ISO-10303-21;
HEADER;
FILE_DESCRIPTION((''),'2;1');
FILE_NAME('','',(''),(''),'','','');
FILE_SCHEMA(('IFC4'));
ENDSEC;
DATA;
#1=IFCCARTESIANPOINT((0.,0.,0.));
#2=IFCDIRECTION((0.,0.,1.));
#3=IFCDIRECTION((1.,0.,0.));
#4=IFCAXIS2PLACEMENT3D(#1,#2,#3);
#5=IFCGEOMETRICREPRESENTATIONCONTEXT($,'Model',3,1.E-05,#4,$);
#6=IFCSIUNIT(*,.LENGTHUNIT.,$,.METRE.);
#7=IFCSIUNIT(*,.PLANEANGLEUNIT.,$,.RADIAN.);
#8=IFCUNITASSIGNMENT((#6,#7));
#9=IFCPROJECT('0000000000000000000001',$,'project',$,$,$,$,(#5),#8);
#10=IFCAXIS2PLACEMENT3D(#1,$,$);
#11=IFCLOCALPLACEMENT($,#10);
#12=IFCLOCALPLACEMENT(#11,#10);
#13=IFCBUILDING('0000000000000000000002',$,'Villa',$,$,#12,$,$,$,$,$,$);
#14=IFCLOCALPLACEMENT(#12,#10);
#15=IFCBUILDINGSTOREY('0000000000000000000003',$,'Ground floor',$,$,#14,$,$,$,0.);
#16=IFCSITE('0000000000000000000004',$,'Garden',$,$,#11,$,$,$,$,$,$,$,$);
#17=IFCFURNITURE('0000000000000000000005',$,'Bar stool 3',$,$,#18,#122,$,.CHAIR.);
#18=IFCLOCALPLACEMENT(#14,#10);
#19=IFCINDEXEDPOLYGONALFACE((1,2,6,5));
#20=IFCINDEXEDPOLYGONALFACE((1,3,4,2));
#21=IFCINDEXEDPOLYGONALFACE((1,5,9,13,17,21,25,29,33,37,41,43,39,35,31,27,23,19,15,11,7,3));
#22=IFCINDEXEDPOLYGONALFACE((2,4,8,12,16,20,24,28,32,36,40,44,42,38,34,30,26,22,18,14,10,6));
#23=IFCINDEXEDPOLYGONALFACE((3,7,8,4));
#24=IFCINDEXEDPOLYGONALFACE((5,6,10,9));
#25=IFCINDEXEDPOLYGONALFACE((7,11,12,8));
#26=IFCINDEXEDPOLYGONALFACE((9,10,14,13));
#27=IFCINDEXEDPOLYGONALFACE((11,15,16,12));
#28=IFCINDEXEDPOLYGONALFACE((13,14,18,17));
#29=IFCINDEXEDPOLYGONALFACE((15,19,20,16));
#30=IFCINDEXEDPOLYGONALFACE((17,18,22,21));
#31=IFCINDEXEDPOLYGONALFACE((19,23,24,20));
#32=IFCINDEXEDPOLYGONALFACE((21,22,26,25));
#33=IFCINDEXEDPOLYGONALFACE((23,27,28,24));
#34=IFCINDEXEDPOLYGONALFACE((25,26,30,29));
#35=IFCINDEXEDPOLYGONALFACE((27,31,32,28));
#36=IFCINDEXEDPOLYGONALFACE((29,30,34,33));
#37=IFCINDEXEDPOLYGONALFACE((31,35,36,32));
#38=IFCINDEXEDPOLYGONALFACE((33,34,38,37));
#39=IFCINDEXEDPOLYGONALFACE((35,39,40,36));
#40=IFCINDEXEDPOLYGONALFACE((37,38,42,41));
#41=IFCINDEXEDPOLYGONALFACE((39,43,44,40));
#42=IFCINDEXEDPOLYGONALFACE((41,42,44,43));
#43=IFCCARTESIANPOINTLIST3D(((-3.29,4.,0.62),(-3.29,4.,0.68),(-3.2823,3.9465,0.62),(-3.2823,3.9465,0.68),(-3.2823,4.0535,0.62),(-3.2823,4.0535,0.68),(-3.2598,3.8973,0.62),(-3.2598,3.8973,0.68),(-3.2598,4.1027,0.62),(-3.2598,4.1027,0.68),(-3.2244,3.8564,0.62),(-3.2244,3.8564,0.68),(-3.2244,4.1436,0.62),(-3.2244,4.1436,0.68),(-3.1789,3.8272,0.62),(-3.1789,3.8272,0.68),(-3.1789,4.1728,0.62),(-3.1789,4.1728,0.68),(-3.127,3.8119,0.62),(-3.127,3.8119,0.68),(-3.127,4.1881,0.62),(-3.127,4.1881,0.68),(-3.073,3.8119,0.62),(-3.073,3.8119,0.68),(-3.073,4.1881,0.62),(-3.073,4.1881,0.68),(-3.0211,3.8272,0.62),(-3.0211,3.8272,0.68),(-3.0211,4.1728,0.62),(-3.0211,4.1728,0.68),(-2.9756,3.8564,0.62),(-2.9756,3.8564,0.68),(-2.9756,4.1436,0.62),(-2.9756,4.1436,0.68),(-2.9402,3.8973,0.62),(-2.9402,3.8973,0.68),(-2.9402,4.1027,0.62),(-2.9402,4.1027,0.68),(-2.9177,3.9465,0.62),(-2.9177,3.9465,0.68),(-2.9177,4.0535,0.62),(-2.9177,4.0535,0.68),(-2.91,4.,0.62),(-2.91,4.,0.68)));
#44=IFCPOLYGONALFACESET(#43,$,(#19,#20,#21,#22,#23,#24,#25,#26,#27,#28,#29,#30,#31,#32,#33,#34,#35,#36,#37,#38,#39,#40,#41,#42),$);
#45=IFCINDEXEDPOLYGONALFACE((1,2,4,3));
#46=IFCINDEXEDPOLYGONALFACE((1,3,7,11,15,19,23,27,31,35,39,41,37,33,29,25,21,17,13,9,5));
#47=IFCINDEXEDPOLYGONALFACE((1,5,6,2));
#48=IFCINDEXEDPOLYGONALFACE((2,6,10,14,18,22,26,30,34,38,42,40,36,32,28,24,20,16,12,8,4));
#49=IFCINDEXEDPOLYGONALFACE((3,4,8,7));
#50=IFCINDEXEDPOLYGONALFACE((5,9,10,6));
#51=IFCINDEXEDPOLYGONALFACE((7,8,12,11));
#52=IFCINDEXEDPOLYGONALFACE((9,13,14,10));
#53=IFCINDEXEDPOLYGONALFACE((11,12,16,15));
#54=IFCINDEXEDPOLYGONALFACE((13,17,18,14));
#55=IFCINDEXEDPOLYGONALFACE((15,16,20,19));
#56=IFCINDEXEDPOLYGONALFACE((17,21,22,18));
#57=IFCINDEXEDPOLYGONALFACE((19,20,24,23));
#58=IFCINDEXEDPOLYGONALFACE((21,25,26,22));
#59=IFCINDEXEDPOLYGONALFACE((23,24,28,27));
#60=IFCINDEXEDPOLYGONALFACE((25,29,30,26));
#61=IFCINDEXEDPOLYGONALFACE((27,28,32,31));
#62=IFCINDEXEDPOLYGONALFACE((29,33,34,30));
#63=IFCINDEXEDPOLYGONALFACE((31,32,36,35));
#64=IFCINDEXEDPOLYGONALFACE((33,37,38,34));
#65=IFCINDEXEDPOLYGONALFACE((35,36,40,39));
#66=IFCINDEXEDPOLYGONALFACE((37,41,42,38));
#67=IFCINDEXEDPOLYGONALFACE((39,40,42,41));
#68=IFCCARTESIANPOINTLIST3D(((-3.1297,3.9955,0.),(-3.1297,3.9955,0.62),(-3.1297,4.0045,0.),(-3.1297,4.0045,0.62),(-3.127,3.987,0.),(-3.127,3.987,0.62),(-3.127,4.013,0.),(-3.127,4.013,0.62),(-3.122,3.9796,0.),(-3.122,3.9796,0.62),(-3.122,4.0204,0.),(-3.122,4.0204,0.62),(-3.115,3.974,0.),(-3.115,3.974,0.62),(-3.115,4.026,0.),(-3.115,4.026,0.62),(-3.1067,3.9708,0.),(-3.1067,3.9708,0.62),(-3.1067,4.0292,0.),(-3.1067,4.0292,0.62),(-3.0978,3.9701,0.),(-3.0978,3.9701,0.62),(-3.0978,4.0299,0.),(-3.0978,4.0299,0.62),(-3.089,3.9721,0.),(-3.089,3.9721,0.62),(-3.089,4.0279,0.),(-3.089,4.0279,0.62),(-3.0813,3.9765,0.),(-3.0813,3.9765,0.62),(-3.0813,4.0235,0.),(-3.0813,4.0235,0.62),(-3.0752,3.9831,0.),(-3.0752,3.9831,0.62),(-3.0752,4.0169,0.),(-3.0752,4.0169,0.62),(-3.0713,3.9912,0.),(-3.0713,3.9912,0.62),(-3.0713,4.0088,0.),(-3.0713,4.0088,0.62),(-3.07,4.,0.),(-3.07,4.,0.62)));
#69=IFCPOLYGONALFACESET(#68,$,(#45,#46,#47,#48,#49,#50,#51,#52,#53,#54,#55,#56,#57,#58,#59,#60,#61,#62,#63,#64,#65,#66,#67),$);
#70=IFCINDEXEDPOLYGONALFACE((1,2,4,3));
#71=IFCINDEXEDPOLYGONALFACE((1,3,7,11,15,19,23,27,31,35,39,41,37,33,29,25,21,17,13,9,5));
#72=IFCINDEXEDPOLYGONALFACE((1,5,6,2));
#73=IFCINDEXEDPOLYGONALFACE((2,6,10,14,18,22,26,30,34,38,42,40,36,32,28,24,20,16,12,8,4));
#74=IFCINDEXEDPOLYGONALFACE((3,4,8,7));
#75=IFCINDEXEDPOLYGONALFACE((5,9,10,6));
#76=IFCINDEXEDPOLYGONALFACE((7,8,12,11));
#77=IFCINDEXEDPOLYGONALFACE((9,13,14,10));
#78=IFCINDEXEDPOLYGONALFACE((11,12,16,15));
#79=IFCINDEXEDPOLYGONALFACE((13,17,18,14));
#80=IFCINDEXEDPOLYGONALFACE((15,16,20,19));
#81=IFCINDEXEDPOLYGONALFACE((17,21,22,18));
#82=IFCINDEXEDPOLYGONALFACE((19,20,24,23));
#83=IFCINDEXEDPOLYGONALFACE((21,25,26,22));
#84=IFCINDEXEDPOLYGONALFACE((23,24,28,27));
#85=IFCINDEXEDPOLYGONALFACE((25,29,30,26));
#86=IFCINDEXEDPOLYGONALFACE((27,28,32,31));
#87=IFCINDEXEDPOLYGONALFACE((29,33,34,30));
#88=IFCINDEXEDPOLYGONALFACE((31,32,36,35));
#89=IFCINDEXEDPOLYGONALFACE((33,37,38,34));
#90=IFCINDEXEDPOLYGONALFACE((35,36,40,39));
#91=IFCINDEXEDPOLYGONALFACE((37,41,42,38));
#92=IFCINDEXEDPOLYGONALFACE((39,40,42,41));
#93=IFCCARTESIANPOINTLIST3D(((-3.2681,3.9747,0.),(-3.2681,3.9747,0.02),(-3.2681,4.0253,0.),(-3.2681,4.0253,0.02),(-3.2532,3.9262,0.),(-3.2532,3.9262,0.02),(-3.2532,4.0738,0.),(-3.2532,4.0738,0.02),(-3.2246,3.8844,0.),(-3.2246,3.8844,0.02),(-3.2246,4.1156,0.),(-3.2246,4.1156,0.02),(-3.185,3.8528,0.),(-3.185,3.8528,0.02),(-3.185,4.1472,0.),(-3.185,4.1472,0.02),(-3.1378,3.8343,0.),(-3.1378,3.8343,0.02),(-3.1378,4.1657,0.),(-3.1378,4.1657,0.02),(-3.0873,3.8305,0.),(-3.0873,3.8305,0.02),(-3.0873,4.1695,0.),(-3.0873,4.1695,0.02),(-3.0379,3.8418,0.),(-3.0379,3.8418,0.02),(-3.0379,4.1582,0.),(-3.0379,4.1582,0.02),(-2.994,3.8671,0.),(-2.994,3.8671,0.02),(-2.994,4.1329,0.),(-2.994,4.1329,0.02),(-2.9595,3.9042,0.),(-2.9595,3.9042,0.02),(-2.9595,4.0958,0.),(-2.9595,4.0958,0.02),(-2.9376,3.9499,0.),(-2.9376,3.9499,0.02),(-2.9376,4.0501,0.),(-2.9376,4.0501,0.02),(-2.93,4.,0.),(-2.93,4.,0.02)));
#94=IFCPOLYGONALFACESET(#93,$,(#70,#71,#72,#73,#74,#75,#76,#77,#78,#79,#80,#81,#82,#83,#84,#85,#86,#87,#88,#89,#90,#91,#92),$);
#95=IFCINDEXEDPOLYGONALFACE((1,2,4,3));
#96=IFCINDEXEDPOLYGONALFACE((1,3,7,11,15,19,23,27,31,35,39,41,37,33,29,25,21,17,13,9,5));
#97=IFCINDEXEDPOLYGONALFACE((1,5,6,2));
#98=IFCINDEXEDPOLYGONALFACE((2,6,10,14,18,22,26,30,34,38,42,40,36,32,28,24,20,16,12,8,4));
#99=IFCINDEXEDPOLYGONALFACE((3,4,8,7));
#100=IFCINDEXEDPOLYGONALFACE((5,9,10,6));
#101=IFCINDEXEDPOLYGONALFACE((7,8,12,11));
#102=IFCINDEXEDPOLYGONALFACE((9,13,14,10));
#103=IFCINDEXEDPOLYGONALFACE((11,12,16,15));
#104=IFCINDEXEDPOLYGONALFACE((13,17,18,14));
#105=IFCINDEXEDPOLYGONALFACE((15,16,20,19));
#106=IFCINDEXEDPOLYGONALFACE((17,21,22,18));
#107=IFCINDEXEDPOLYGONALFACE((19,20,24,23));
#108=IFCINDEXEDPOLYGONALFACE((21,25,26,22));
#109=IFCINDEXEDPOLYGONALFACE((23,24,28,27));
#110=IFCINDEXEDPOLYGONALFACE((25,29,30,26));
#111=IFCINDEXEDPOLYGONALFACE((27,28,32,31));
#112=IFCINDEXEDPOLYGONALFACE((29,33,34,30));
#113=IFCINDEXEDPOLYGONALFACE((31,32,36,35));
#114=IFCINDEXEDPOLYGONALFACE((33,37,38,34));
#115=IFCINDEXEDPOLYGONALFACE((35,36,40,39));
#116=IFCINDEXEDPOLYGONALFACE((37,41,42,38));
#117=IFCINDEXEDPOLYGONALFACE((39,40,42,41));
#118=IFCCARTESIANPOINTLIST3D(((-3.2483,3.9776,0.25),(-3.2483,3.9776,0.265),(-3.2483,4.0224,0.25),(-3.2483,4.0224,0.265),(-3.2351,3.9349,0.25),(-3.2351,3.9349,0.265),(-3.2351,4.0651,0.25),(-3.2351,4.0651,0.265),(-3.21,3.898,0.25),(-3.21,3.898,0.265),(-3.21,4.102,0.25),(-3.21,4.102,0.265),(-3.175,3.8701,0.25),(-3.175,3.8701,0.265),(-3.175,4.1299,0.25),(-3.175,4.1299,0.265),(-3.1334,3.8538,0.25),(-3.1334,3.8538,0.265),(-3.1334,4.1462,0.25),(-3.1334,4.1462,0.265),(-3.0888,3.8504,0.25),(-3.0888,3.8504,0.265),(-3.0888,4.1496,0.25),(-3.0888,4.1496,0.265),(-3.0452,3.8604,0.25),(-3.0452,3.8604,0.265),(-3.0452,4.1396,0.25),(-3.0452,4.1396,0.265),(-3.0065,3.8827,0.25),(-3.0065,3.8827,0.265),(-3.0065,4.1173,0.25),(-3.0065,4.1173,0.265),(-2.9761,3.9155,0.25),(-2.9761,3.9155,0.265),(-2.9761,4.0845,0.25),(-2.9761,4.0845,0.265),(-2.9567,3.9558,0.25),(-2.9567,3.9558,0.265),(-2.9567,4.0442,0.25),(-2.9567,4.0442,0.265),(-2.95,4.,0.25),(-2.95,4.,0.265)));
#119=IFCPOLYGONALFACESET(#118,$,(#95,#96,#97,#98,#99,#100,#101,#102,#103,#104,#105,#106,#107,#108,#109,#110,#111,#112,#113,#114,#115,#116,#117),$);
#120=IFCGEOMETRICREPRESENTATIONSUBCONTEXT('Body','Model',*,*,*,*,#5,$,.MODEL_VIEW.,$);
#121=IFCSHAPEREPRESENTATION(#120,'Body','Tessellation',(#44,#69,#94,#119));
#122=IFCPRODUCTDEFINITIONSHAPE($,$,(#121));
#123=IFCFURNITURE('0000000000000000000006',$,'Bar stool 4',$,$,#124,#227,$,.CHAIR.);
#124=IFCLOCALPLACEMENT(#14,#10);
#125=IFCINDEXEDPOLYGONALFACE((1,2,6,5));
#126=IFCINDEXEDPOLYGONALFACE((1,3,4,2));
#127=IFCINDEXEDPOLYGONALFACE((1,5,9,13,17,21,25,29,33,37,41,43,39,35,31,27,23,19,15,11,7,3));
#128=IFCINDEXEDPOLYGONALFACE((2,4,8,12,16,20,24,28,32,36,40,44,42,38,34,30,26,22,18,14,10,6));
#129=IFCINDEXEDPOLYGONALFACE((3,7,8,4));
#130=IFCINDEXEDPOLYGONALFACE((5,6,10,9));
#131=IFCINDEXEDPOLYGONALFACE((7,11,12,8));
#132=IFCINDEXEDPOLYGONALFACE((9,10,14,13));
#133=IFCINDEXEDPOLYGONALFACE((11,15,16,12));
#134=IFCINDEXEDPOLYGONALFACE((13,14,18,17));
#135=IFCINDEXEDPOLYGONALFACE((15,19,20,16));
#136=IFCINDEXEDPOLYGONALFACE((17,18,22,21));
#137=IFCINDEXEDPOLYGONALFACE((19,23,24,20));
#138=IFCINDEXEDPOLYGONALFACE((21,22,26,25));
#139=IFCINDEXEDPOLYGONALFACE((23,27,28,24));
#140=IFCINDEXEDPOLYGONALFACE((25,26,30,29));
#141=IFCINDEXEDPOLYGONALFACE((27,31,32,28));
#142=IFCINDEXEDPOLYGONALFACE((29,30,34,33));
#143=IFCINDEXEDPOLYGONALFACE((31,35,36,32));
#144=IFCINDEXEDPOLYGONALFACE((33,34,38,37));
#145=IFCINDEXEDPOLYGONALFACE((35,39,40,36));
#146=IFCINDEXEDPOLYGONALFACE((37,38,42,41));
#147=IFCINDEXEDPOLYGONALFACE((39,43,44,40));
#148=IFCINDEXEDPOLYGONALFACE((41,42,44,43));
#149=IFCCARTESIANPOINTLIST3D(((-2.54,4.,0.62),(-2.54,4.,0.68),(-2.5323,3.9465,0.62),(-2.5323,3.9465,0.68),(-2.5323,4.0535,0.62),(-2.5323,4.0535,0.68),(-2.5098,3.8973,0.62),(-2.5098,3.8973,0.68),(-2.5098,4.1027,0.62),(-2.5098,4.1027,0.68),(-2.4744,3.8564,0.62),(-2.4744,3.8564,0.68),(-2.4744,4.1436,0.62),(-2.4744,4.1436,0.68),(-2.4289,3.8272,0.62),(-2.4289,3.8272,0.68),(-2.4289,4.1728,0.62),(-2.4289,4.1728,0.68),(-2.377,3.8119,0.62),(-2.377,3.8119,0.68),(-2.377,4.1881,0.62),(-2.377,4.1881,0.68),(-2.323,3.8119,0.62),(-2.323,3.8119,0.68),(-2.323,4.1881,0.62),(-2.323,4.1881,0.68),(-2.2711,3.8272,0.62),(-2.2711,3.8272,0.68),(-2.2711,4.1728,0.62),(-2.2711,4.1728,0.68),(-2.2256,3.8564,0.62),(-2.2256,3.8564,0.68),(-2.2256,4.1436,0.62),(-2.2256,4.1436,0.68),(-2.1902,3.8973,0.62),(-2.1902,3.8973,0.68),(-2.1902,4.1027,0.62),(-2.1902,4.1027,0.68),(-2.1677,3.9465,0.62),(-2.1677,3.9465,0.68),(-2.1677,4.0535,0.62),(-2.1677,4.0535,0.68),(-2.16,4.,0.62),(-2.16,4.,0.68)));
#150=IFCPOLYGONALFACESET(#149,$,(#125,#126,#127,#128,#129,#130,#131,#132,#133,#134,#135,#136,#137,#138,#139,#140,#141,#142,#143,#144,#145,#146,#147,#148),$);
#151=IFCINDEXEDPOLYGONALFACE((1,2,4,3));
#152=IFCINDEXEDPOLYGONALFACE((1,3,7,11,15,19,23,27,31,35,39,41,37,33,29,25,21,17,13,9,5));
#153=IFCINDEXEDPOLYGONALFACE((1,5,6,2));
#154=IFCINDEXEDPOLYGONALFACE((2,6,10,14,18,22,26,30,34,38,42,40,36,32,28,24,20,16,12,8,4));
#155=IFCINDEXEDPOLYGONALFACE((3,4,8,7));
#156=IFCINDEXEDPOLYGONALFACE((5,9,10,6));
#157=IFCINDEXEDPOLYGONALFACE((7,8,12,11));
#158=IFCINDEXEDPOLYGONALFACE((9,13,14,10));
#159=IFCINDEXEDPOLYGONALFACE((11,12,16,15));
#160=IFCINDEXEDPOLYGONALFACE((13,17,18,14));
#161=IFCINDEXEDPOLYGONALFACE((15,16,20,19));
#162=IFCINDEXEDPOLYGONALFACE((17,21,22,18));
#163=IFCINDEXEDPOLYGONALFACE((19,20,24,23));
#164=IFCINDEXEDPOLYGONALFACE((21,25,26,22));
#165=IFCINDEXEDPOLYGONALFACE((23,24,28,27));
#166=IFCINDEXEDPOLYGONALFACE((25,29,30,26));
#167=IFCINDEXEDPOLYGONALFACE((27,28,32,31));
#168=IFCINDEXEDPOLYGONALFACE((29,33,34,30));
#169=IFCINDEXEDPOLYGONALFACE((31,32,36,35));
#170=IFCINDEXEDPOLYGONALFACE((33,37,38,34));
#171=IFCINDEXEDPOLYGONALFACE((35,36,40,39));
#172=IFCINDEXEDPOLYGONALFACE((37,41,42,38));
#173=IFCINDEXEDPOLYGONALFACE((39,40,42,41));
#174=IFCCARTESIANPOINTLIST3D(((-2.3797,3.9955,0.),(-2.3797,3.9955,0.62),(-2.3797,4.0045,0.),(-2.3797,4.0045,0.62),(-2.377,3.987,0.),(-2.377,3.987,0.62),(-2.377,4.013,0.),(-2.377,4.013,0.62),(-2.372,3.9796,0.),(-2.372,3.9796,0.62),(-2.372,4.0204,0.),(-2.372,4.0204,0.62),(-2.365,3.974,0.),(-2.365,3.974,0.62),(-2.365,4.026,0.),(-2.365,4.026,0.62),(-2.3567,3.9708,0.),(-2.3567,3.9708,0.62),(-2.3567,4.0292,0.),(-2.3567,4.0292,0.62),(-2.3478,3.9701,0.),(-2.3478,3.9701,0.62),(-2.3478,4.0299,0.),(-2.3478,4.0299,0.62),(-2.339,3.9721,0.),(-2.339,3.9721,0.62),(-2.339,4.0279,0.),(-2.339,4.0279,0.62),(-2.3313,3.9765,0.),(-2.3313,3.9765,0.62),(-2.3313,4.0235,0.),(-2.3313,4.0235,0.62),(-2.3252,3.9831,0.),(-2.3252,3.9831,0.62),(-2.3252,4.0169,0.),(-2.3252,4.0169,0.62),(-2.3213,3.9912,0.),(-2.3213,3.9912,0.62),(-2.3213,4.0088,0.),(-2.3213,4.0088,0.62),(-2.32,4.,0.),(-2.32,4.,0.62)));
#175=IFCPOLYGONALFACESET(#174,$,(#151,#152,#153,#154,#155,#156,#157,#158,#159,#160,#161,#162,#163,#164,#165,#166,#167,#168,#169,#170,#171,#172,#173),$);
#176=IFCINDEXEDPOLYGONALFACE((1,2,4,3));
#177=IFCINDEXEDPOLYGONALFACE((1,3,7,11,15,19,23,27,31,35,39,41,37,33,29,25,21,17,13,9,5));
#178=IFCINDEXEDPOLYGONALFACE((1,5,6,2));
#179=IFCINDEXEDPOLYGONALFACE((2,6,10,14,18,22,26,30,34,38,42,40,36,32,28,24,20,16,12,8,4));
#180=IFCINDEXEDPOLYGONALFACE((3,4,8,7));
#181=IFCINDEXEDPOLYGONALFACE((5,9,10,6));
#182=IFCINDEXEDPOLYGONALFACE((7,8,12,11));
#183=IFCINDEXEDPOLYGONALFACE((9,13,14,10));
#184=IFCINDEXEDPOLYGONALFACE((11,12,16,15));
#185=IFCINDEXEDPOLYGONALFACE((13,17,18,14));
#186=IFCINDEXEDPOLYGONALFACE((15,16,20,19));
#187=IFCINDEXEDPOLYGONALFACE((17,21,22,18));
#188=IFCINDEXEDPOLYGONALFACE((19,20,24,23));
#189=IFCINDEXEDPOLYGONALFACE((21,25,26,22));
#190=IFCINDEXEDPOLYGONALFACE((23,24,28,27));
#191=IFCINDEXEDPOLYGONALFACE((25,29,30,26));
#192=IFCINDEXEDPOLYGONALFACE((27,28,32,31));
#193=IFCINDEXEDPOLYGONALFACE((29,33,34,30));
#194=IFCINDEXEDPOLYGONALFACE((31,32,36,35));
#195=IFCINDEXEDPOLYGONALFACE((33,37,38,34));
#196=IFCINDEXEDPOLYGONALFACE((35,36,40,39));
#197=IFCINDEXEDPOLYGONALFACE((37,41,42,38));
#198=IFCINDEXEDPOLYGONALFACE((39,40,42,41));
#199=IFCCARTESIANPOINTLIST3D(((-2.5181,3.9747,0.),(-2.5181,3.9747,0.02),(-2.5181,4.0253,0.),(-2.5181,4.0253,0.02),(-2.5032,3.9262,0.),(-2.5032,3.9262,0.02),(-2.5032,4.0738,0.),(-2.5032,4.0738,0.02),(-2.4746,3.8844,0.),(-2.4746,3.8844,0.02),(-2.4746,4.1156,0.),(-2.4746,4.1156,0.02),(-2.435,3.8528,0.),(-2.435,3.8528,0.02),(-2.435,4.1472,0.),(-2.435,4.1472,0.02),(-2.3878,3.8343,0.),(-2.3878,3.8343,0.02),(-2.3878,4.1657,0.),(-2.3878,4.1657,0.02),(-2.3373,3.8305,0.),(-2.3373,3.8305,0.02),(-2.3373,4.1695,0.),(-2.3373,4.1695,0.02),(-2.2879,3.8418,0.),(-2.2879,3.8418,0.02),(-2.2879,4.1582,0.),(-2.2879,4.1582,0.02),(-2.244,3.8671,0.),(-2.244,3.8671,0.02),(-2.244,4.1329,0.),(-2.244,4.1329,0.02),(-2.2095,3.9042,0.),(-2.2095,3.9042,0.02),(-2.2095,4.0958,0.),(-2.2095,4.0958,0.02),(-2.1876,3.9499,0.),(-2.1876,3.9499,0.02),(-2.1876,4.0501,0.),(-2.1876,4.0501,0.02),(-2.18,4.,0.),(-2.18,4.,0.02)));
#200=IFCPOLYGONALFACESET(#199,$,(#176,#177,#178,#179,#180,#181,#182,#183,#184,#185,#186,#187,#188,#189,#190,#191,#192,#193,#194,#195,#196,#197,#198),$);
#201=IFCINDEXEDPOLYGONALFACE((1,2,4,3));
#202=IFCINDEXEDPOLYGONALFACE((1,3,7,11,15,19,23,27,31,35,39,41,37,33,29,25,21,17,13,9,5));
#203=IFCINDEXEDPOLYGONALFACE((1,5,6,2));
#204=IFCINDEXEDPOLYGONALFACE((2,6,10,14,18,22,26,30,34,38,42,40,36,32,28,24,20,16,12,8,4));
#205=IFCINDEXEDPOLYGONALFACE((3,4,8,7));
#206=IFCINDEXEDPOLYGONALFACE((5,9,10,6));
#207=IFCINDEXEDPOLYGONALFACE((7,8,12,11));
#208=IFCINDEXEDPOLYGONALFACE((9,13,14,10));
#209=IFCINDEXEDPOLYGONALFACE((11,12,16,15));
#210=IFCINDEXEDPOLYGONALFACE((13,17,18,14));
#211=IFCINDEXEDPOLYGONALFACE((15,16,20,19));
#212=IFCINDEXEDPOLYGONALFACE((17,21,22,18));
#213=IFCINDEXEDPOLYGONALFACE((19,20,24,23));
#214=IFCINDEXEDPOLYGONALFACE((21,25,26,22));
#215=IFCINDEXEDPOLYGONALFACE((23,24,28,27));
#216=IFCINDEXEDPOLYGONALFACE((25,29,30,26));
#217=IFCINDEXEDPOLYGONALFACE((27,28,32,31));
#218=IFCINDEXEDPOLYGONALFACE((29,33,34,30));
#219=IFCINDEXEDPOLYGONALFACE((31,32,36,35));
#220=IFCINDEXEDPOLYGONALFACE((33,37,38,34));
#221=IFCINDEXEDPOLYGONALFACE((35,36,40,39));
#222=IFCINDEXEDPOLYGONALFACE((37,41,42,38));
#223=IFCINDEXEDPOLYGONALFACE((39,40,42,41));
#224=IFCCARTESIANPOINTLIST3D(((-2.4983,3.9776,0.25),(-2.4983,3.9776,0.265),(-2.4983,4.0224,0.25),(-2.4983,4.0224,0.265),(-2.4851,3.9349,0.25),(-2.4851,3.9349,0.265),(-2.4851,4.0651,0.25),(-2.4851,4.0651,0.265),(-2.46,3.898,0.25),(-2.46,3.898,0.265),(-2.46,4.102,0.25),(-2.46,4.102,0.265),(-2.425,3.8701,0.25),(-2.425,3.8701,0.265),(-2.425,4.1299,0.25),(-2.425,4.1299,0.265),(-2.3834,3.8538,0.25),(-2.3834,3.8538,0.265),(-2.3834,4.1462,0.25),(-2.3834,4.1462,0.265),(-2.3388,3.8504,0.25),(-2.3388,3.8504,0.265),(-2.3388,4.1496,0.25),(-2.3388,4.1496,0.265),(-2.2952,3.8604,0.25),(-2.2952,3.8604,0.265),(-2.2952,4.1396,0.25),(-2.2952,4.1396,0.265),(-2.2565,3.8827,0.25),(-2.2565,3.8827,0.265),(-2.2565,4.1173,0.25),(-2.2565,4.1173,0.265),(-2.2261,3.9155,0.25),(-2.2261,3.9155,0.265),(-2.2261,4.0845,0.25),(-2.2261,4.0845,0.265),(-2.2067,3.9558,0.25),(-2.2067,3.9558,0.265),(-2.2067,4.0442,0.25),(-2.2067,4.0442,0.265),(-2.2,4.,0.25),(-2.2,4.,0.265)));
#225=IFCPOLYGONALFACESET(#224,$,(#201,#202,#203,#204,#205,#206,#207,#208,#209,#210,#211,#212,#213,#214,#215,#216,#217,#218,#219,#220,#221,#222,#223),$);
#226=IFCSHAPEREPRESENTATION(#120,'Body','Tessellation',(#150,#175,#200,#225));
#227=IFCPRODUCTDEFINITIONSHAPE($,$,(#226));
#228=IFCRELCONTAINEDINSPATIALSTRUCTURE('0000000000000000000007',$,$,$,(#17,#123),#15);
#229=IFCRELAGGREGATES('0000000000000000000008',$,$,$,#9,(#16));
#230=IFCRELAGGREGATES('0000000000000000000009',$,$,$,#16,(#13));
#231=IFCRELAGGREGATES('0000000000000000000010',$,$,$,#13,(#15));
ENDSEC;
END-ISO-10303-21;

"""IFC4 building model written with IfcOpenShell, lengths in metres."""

from ifc_helpers import new_model, si_unit, frame, origin, origin_with_axes, origin_2d, place, context, subcontext, project, spatial, circle, extrude, element, save


model = new_model("IFC4")

# Units and contexts
model_context = context("Model", 3, precision=1e-05, world=origin_with_axes())
body_context = subcontext(model_context, "Body", "Model", "MODEL_VIEW")
ifc_project = project(units=[si_unit("LENGTHUNIT", "METRE"), si_unit("PLANEANGLEUNIT", "RADIAN")], contexts=[model_context])

# Site, building, storey
site_placement = place(None, origin())
site = spatial("IfcSite", under=ifc_project, at=site_placement, Name="Garden")
building_placement = place(site_placement, origin())
building = spatial("IfcBuilding", under=site, at=building_placement, Name="Villa")
storey_placement = place(building_placement, origin())
storey = spatial("IfcBuildingStorey", under=building, at=storey_placement, Name="Ground floor", Elevation=0.0)

# Furniture
for number, where, name in (
    (1, (-3.1, 4.0, 0.0), "Bar stool 3"),
    (2, (-2.35, 4.0, 0.0), "Bar stool 4"),
):
    element("IfcFurniture", number, at=place(storey_placement, frame(where)), inside=storey, Name=name, PredefinedType="CHAIR", context=body_context, shape_type="SweptSolid", body=[
        extrude(circle(Radius=0.19, at=origin_2d()), frame((0.0, 0.0, 0.62)), (0.0, 0.0, 1.0), 0.06),
        extrude(circle(Radius=0.03, at=origin_2d()), origin(), (0.0, 0.0, 1.0), 0.62),
        extrude(circle(Radius=0.17, at=origin_2d()), origin(), (0.0, 0.0, 1.0), 0.02),
        extrude(circle(Radius=0.15, at=origin_2d()), frame((0.0, 0.0, 0.25)), (0.0, 0.0, 1.0), 0.015),
    ])

save(model, "model.ifc")
